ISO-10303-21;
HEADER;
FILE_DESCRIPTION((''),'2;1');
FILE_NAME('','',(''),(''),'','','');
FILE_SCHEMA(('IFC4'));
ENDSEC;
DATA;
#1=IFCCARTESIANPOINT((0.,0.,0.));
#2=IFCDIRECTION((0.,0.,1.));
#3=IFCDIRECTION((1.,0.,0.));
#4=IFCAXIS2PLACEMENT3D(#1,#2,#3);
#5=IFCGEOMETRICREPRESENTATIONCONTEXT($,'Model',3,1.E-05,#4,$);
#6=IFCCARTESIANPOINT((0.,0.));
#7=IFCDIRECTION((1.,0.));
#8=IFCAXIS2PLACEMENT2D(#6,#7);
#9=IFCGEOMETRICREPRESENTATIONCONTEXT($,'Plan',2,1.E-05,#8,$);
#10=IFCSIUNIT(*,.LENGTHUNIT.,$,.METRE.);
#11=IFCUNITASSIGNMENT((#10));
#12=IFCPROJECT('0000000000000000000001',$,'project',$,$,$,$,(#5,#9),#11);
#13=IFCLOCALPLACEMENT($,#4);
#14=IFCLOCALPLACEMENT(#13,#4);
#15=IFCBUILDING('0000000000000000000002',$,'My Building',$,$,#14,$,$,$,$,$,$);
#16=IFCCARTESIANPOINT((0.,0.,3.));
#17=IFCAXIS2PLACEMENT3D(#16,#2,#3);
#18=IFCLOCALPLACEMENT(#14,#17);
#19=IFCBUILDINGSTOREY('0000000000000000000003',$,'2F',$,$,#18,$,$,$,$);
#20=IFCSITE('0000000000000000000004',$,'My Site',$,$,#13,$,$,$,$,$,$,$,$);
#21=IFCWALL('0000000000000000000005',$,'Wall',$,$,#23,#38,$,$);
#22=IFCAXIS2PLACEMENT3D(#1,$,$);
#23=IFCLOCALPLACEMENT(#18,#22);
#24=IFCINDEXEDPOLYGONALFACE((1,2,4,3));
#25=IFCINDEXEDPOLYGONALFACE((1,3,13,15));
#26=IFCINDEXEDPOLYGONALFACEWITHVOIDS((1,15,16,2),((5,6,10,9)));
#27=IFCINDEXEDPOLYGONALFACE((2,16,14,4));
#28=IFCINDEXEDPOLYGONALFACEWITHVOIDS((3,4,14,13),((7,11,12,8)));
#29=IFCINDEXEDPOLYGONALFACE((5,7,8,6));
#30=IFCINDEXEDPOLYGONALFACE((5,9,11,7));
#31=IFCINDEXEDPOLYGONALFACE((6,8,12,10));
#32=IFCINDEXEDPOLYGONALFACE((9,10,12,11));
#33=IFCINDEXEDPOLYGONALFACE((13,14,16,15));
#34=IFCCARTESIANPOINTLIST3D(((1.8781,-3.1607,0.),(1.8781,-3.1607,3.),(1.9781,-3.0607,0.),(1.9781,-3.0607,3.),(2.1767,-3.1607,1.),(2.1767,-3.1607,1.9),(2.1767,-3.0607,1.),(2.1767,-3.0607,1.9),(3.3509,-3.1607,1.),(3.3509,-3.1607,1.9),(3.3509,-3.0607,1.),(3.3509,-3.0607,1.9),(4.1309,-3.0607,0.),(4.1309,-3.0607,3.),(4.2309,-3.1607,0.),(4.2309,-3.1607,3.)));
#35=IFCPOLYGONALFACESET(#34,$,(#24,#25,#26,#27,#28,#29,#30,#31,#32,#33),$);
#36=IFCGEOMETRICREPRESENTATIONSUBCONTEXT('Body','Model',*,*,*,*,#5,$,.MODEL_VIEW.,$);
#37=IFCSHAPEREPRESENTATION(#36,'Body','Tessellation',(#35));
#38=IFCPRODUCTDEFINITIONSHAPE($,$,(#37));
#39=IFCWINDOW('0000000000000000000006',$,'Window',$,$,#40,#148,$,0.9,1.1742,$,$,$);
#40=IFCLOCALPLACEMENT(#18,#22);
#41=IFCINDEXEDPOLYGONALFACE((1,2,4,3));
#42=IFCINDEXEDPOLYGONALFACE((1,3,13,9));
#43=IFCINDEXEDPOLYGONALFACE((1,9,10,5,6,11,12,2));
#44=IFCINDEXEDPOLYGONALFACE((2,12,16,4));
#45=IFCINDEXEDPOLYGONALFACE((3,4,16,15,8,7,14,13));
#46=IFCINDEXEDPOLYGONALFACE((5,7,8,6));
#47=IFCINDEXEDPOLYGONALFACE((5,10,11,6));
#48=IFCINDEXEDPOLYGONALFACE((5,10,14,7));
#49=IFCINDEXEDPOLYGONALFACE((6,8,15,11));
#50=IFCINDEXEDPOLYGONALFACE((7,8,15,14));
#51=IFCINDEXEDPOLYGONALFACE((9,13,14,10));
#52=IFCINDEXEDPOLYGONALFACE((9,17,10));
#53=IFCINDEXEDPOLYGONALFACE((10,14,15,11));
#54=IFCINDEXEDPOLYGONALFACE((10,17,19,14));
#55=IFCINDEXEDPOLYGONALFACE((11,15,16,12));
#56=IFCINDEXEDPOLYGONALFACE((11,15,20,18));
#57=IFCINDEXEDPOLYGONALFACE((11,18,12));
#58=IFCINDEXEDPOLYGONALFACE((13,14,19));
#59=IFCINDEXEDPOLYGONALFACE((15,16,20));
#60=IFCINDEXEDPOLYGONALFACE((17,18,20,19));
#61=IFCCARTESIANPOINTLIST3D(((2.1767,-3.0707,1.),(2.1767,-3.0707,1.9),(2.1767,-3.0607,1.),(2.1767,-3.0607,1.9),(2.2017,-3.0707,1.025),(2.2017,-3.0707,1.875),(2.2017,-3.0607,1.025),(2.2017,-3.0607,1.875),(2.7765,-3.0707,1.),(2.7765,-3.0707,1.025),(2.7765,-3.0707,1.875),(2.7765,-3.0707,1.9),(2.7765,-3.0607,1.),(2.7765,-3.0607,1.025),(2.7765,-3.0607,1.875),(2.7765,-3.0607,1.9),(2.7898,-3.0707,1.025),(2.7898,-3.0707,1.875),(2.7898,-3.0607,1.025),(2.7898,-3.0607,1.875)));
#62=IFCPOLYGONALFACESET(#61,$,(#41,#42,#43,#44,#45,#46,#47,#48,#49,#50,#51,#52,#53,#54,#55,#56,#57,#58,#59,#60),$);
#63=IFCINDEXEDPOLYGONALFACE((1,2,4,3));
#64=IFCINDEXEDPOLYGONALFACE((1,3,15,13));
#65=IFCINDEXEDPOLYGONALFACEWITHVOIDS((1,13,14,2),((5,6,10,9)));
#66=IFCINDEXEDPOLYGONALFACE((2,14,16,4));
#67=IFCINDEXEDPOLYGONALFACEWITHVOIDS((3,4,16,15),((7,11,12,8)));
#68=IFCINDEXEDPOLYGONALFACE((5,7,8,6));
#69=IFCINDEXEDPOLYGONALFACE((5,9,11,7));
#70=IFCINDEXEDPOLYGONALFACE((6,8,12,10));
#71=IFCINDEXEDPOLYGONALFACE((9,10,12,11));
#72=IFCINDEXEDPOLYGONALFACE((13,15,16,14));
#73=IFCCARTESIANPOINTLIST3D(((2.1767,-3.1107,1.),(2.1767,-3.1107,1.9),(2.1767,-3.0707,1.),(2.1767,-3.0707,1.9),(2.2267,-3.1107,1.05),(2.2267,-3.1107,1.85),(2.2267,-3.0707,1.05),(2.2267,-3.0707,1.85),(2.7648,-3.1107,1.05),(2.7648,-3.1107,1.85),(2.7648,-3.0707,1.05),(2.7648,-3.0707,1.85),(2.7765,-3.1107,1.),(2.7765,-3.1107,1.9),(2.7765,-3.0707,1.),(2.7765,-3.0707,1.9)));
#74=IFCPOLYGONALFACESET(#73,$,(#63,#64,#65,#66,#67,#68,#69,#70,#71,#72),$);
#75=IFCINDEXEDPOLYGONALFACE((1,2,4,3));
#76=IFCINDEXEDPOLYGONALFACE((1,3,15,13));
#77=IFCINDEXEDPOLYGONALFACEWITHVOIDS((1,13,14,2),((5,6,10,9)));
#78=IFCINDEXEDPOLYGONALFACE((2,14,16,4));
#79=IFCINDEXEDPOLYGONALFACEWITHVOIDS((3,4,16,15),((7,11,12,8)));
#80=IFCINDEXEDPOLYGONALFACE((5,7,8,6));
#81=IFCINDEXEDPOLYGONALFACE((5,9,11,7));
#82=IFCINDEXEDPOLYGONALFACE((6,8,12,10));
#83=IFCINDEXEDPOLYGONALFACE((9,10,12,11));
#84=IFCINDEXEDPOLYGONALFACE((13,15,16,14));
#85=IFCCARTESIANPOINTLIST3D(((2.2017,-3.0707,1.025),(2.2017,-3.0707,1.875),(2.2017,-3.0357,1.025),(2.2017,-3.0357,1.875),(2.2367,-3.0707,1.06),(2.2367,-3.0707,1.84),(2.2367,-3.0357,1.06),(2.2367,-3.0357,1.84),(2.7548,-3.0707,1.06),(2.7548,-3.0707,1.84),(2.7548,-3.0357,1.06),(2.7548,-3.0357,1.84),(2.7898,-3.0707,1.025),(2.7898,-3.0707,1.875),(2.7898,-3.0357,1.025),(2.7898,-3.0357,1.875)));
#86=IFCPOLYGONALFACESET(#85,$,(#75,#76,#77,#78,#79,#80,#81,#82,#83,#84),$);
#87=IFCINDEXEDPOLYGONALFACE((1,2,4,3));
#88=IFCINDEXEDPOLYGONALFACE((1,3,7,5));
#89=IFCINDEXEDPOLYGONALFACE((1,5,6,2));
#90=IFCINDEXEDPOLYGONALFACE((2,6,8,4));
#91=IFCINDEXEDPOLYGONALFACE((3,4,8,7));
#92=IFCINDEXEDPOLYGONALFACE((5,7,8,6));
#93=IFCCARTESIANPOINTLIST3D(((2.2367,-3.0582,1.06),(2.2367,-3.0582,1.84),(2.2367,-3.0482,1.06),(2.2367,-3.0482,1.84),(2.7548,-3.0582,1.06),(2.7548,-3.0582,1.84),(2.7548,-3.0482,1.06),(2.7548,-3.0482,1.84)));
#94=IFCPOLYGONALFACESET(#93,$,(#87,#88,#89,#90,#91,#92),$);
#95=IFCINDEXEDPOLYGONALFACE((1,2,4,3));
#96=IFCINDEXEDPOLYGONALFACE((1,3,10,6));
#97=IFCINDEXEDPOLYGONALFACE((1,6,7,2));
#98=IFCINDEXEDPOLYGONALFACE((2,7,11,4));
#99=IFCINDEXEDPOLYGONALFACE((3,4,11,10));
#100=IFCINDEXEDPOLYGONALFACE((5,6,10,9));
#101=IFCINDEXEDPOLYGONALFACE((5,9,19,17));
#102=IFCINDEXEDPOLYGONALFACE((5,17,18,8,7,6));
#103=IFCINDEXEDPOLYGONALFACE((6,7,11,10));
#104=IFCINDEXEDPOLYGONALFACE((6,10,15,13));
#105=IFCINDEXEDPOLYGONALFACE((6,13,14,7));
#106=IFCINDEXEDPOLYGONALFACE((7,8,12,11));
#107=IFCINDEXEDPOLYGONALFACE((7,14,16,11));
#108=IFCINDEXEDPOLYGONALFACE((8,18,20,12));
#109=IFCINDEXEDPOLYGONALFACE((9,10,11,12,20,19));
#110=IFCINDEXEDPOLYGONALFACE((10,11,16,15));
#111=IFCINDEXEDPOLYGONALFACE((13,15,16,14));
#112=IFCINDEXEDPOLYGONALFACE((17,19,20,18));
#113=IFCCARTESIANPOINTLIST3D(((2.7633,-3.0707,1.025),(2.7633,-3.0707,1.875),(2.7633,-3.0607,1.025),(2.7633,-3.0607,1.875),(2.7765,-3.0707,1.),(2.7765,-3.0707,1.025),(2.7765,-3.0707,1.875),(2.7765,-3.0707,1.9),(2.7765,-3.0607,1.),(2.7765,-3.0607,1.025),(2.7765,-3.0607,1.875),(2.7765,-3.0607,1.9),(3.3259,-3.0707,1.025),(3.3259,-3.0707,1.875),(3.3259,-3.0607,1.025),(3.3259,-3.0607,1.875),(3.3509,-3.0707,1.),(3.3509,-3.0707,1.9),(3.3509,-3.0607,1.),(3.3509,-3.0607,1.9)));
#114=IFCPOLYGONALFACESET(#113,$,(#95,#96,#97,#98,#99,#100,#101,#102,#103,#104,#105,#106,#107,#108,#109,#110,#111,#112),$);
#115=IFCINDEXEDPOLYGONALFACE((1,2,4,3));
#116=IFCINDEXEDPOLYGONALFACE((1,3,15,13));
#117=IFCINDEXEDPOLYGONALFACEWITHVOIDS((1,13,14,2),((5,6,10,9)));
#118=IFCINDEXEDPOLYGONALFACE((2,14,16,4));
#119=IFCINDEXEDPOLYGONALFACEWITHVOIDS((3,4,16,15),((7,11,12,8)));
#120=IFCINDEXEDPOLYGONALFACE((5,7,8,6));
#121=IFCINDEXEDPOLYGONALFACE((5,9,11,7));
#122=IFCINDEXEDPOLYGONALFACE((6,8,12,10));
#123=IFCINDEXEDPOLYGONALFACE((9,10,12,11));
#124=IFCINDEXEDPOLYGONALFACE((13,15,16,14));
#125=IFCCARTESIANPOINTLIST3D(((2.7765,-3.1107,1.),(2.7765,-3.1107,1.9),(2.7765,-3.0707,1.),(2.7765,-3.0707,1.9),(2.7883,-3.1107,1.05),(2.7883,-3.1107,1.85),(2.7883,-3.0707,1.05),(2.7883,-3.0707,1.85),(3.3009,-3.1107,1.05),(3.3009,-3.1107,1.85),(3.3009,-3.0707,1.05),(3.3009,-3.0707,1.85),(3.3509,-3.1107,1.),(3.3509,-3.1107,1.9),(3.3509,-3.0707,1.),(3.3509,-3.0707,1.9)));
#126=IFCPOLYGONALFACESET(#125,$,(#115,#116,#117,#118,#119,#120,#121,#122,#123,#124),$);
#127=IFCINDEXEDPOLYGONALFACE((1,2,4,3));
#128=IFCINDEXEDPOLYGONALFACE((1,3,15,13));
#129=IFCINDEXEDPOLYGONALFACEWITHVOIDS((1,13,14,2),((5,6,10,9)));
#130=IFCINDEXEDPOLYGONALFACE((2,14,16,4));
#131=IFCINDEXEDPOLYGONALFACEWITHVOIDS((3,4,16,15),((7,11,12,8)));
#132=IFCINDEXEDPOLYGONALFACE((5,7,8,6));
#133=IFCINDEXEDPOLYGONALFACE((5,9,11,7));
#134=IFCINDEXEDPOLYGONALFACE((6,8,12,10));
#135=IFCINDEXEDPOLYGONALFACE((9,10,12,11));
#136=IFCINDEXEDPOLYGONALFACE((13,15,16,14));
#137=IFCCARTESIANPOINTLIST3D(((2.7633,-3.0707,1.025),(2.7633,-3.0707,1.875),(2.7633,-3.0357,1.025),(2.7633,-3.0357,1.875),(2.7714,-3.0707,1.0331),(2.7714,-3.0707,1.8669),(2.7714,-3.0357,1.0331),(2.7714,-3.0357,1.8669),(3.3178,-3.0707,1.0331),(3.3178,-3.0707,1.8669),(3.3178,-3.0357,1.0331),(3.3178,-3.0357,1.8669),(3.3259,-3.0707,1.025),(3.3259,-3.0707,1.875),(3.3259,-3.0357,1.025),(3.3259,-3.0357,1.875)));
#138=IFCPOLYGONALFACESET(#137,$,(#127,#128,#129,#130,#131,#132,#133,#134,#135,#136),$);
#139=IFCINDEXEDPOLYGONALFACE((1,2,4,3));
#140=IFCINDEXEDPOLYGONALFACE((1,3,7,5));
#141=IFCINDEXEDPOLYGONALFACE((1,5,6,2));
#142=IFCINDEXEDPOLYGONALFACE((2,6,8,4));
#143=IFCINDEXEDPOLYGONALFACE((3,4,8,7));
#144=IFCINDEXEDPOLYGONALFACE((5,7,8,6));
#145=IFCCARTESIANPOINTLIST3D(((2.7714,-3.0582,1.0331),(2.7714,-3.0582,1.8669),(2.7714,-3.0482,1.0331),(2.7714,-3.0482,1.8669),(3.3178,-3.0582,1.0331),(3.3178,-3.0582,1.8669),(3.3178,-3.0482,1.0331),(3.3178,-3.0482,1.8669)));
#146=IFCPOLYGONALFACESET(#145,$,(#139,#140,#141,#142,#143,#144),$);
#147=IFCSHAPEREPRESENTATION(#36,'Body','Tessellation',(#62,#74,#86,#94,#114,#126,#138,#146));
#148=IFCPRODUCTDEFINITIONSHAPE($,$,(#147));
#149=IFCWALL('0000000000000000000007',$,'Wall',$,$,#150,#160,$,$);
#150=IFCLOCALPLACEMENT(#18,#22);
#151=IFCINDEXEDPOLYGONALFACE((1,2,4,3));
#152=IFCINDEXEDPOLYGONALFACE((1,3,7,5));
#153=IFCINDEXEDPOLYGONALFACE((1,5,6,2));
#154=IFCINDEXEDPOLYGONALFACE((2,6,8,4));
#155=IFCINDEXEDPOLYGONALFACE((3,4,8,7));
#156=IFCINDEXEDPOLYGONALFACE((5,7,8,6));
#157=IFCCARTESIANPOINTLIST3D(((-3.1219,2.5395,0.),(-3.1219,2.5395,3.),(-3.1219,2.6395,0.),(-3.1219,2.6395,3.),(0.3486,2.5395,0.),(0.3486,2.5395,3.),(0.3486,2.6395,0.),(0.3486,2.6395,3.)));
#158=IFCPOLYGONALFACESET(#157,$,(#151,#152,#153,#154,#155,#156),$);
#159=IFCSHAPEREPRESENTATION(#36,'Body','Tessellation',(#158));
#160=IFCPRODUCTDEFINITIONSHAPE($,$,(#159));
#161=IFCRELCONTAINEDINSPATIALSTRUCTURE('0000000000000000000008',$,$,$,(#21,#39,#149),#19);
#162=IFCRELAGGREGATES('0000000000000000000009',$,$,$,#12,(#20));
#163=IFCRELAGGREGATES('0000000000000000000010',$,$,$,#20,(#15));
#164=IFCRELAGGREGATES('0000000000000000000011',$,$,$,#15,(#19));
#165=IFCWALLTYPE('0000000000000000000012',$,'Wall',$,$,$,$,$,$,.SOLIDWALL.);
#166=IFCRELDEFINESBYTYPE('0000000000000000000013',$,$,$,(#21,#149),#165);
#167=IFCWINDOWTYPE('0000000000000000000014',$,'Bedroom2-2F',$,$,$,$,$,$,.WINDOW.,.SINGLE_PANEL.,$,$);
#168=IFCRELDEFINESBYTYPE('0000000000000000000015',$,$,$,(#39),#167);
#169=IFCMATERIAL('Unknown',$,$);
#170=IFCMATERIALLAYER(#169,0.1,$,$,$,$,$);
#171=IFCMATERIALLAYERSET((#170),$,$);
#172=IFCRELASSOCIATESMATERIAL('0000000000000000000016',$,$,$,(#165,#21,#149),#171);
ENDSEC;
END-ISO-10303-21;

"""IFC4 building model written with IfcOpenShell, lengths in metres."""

from ifc_helpers import new_model, entity, si_unit, frame, origin_with_axes, origin_2d_with_axis, place, context, subcontext, project, spatial, line, indexed_curve, outline, extrude, shape, source, transform, mapped, material, layer, layer_set, layer_usage, type_object, type_shapes, element, fill, save


model = new_model("IFC4")

# Units and contexts
model_context = context("Model", 3, precision=1e-05, world=origin_with_axes())
plan_context = context("Plan", 2, precision=1e-05, world=origin_2d_with_axis())
body_context_1 = subcontext(model_context, "Body", "Model", "MODEL_VIEW")
body_context_2 = subcontext(plan_context, "Body", "Plan", "PLAN_VIEW")
ifc_project = project(units=[si_unit("LENGTHUNIT", "METRE")], contexts=[model_context, plan_context])

# Site, building, storey
site_placement = place(None, origin_with_axes())
site = spatial("IfcSite", under=ifc_project, at=site_placement, Name="My Site")
building_placement = place(site_placement, origin_with_axes())
building = spatial("IfcBuilding", under=site, at=building_placement, Name="My Building")
storey_placement = place(building_placement, frame((0.0, 0.0, 3.0), z_axis=(0.0, 0.0, 1.0), x_axis=(1.0, 0.0, 0.0)))
storey = spatial("IfcBuildingStorey", under=building, at=storey_placement, Name="2F")

# Shared definitions
ifc_material = material(Name="Unknown")
ifc_layer = layer(ifc_material, 0.1)
ifc_layer_set = layer_set([ifc_layer])
wall_type = type_object("IfcWallType", Name="Wall", PredefinedType="SOLIDWALL", material=ifc_layer_set)

# Wall, opening, window
ifc_layer_usage_1 = layer_usage(ifc_layer_set, "AXIS2", "POSITIVE", 0.0)
wall_1_placement = place(storey_placement, frame((1.8781, -3.1607, 0.0), z_axis=(0.0, 0.0, 1.0), x_axis=(1.0, 0.0, 0.0)))
wall_1 = element("IfcWall", 1, at=wall_1_placement, inside=storey, type_object=wall_type, material=ifc_layer_usage_1, Name="Wall", context=body_context_1, shape_type="SweptSolid", body=[
    extrude(outline(indexed_curve([(0.0, 0.0), (0.1, 0.1), (2.2528, 0.1), (2.3528, 0.0)], segments=[line(1, 2, 3, 4, 1)])), origin_with_axes(), (0.0, 0.0, 1.0), 3.0),
])
shared_shape_1 = source(origin_with_axes(), body_context_1, "Body", "SweptSolid", [
    extrude(outline(indexed_curve([(0.0, 0.0), (1.1742, 0.0), (1.1742, 0.9), (0.0, 0.9)], segments=[line(1, 2, 3, 4, 1)])), frame((0.0, -0.6, 0.0), z_axis=(0.0, -1.0, 0.0), x_axis=(1.0, 0.0, 0.0)), (0.0, 0.0, -1.0), 1.2),
])
opening_1_placement = place(wall_1_placement, frame((0.2985, 0.0, 1.0), z_axis=(0.0, 0.0, 1.0), x_axis=(1.0, 0.0, 0.0)))
opening_1 = element("IfcOpeningElement", 2, at=opening_1_placement, cuts=wall_1, PredefinedType="OPENING", context=body_context_1, shape_type="MappedRepresentation", body=[
    mapped(shared_shape_1, transform((0.0, 0.0, 0.0), x_axis=(1.0, 0.0, 0.0), y_axis=(0.0, 1.0, 0.0), z_axis=(0.0, 0.0, 1.0), scale=1.0)),
])
window_type_1 = type_object("IfcWindowType", Name="Bedroom2-2F", PartitioningType="SINGLE_PANEL", PredefinedType="WINDOW")
shared_shape_2 = source(origin_with_axes(), body_context_1, "Body", "SweptSolid", [
    extrude(outline(indexed_curve([(0.0, 0.0), (0.5999, 0.0), (0.5999, 0.9), (0.0, 0.9)], segments=[line(1, 2, 3, 4, 1)]), holes=[indexed_curve([(0.025, 0.025), (0.6131, 0.025), (0.6131, 0.875), (0.025, 0.875)], segments=[line(1, 2, 3, 4, 1)])]), frame((0.0, 0.09, 0.0), z_axis=(0.0, -1.0, 0.0), x_axis=(1.0, 0.0, 0.0)), (0.0, 0.0, -1.0), 0.01),
    extrude(outline(indexed_curve([(0.0, 0.0), (0.5999, 0.0), (0.5999, 0.9), (0.0, 0.9)], segments=[line(1, 2, 3, 4, 1)]), holes=[indexed_curve([(0.05, 0.05), (0.5881, 0.05), (0.5881, 0.85), (0.05, 0.85)], segments=[line(1, 2, 3, 4, 1)])]), frame((0.0, 0.05, 0.0), z_axis=(0.0, -1.0, 0.0), x_axis=(1.0, 0.0, 0.0)), (0.0, 0.0, -1.0), 0.04),
    extrude(outline(indexed_curve([(0.0, 0.0), (0.5881, 0.0), (0.5881, 0.85), (0.0, 0.85)], segments=[line(1, 2, 3, 4, 1)]), holes=[indexed_curve([(0.035, 0.035), (0.5531, 0.035), (0.5531, 0.815), (0.035, 0.815)], segments=[line(1, 2, 3, 4, 1)])]), frame((0.025, 0.09, 0.025), z_axis=(0.0, -1.0, 0.0), x_axis=(1.0, 0.0, 0.0)), (0.0, 0.0, -1.0), 0.035),
    extrude(outline(indexed_curve([(0.035, 0.035), (0.5531, 0.035), (0.5531, 0.815), (0.035, 0.815)], segments=[line(1, 2, 3, 4, 1)])), frame((0.025, 0.1025, 0.025), z_axis=(0.0, -1.0, 0.0), x_axis=(1.0, 0.0, 0.0)), (0.0, 0.0, -1.0), 0.01),
    extrude(outline(indexed_curve([(0.0, 0.0), (0.5744, 0.0), (0.5744, 0.9), (0.0, 0.9)], segments=[line(1, 2, 3, 4, 1)]), holes=[indexed_curve([(-0.0132, 0.025), (0.5494, 0.025), (0.5494, 0.875), (-0.0132, 0.875)], segments=[line(1, 2, 3, 4, 1)])]), frame((0.5999, 0.09, 0.0), z_axis=(0.0, -1.0, 0.0), x_axis=(1.0, 0.0, 0.0)), (0.0, 0.0, -1.0), 0.01),
    extrude(outline(indexed_curve([(0.0, 0.0), (0.5744, 0.0), (0.5744, 0.9), (0.0, 0.9)], segments=[line(1, 2, 3, 4, 1)]), holes=[indexed_curve([(0.0118, 0.05), (0.5244, 0.05), (0.5244, 0.85), (0.0118, 0.85)], segments=[line(1, 2, 3, 4, 1)])]), frame((0.5999, 0.05, 0.0), z_axis=(0.0, -1.0, 0.0), x_axis=(1.0, 0.0, 0.0)), (0.0, 0.0, -1.0), 0.04),
    extrude(outline(indexed_curve([(0.0, 0.0), (0.5626, 0.0), (0.5626, 0.85), (0.0, 0.85)], segments=[line(1, 2, 3, 4, 1)]), holes=[indexed_curve([(0.0081, 0.0081), (0.5545, 0.0081), (0.5545, 0.8419), (0.0081, 0.8419)], segments=[line(1, 2, 3, 4, 1)])]), frame((0.5866, 0.09, 0.025), z_axis=(0.0, -1.0, 0.0), x_axis=(1.0, 0.0, 0.0)), (0.0, 0.0, -1.0), 0.035),
    extrude(outline(indexed_curve([(0.0081, 0.0081), (0.5545, 0.0081), (0.5545, 0.8419), (0.0081, 0.8419)], segments=[line(1, 2, 3, 4, 1)])), frame((0.5866, 0.1025, 0.025), z_axis=(0.0, -1.0, 0.0), x_axis=(1.0, 0.0, 0.0)), (0.0, 0.0, -1.0), 0.01),
])
shared_shape_3 = source(origin_with_axes(), body_context_2, "Body", "Curve2D", [
    entity("IfcIndexedPolyCurve", entity("IfcCartesianPointList2D", [[0.05, 0.05], [0.5881, 0.05]])),
    entity("IfcIndexedPolyCurve", entity("IfcCartesianPointList2D", [[0.0, 0.1], [0.025, 0.1], [0.025, 0.09], [0.05, 0.09], [0.05, 0.05], [0.0, 0.05]]), [entity("IfcLineIndex", [1, 2, 3, 4, 5, 6, 1])]),
    entity("IfcIndexedPolyCurve", entity("IfcCartesianPointList2D", [[0.5999, 0.1], [0.6131, 0.1], [0.6131, 0.09], [0.5881, 0.09], [0.5881, 0.05], [0.5999, 0.05]])),
    entity("IfcIndexedPolyCurve", entity("IfcCartesianPointList2D", [[0.025, 0.09], [0.06, 0.09], [0.06, 0.125], [0.025, 0.125]]), [entity("IfcLineIndex", [1, 2, 3, 4, 1])]),
    entity("IfcIndexedPolyCurve", entity("IfcCartesianPointList2D", [[0.6131, 0.09], [0.5781, 0.09], [0.5781, 0.125], [0.6131, 0.125]]), [entity("IfcLineIndex", [1, 2, 3, 4, 1])]),
    entity("IfcIndexedPolyCurve", entity("IfcCartesianPointList2D", [[0.06, 0.09], [0.5781, 0.09]])),
    entity("IfcIndexedPolyCurve", entity("IfcCartesianPointList2D", [[0.06, 0.125], [0.5781, 0.125]])),
    entity("IfcIndexedPolyCurve", entity("IfcCartesianPointList2D", [[0.06, 0.1075], [0.5781, 0.1075]])),
    entity("IfcIndexedPolyCurve", entity("IfcCartesianPointList2D", [[0.6116, 0.05], [1.1242, 0.05]])),
    entity("IfcIndexedPolyCurve", entity("IfcCartesianPointList2D", [[0.5999, 0.1], [0.5866, 0.1], [0.5866, 0.09], [0.6116, 0.09], [0.6116, 0.05], [0.5999, 0.05]])),
    entity("IfcIndexedPolyCurve", entity("IfcCartesianPointList2D", [[1.1742, 0.1], [1.1492, 0.1], [1.1492, 0.09], [1.1242, 0.09], [1.1242, 0.05], [1.1742, 0.05]]), [entity("IfcLineIndex", [1, 2, 3, 4, 5, 6, 1])]),
    entity("IfcIndexedPolyCurve", entity("IfcCartesianPointList2D", [[0.5866, 0.09], [0.5947, 0.09], [0.5947, 0.125], [0.5866, 0.125]]), [entity("IfcLineIndex", [1, 2, 3, 4, 1])]),
    entity("IfcIndexedPolyCurve", entity("IfcCartesianPointList2D", [[1.1492, 0.09], [1.1412, 0.09], [1.1412, 0.125], [1.1492, 0.125]]), [entity("IfcLineIndex", [1, 2, 3, 4, 1])]),
    entity("IfcIndexedPolyCurve", entity("IfcCartesianPointList2D", [[0.5947, 0.09], [1.1412, 0.09]])),
    entity("IfcIndexedPolyCurve", entity("IfcCartesianPointList2D", [[0.5947, 0.125], [1.1412, 0.125]])),
    entity("IfcIndexedPolyCurve", entity("IfcCartesianPointList2D", [[0.5947, 0.1075], [1.1412, 0.1075]])),
])
type_shapes(window_type_1, [shared_shape_2, shared_shape_3])
window_1_placement = place(opening_1_placement, frame((0.0, 0.0, 0.0), z_axis=(0.0, 0.0, 1.0), x_axis=(1.0, 0.0, 0.0)))
window_1 = element("IfcWindow", 3, at=window_1_placement, inside=storey, type_object=window_type_1, Name="Window", OverallHeight=0.9, OverallWidth=1.1742, shapes=[
    shape(body_context_1, "Body", "MappedRepresentation", [mapped(shared_shape_2, transform((0.0, 0.0, 0.0), x_axis=(1.0, 0.0, 0.0), y_axis=(0.0, 1.0, 0.0), z_axis=(0.0, 0.0, 1.0), scale=1.0))]),
    shape(body_context_2, "Body", "MappedRepresentation", [mapped(shared_shape_3, transform((0.0, 0.0, 0.0), x_axis=(1.0, 0.0, 0.0), y_axis=(0.0, 1.0, 0.0), z_axis=(0.0, 0.0, 1.0), scale=1.0))]),
])
fill(opening_1, window_1)

# Wall
ifc_layer_usage_2 = layer_usage(ifc_layer_set, "AXIS2", "POSITIVE", 0.0)
wall_2_placement = place(storey_placement, frame((0.3486, 2.6395, 0.0), z_axis=(0.0, 0.0, 1.0), x_axis=(-1.0, 0.0, 0.0)))
element("IfcWall", 4, at=wall_2_placement, inside=storey, type_object=wall_type, material=ifc_layer_usage_2, Name="Wall", context=body_context_1, shape_type="SweptSolid", body=[
    extrude(outline(indexed_curve([(0.0, 0.0), (0.0, 0.1), (3.4705, 0.1), (3.4705, 0.0)], segments=[line(1, 2, 3, 4, 1)])), origin_with_axes(), (0.0, 0.0, 1.0), 3.0),
])

save(model, "model.ifc")
